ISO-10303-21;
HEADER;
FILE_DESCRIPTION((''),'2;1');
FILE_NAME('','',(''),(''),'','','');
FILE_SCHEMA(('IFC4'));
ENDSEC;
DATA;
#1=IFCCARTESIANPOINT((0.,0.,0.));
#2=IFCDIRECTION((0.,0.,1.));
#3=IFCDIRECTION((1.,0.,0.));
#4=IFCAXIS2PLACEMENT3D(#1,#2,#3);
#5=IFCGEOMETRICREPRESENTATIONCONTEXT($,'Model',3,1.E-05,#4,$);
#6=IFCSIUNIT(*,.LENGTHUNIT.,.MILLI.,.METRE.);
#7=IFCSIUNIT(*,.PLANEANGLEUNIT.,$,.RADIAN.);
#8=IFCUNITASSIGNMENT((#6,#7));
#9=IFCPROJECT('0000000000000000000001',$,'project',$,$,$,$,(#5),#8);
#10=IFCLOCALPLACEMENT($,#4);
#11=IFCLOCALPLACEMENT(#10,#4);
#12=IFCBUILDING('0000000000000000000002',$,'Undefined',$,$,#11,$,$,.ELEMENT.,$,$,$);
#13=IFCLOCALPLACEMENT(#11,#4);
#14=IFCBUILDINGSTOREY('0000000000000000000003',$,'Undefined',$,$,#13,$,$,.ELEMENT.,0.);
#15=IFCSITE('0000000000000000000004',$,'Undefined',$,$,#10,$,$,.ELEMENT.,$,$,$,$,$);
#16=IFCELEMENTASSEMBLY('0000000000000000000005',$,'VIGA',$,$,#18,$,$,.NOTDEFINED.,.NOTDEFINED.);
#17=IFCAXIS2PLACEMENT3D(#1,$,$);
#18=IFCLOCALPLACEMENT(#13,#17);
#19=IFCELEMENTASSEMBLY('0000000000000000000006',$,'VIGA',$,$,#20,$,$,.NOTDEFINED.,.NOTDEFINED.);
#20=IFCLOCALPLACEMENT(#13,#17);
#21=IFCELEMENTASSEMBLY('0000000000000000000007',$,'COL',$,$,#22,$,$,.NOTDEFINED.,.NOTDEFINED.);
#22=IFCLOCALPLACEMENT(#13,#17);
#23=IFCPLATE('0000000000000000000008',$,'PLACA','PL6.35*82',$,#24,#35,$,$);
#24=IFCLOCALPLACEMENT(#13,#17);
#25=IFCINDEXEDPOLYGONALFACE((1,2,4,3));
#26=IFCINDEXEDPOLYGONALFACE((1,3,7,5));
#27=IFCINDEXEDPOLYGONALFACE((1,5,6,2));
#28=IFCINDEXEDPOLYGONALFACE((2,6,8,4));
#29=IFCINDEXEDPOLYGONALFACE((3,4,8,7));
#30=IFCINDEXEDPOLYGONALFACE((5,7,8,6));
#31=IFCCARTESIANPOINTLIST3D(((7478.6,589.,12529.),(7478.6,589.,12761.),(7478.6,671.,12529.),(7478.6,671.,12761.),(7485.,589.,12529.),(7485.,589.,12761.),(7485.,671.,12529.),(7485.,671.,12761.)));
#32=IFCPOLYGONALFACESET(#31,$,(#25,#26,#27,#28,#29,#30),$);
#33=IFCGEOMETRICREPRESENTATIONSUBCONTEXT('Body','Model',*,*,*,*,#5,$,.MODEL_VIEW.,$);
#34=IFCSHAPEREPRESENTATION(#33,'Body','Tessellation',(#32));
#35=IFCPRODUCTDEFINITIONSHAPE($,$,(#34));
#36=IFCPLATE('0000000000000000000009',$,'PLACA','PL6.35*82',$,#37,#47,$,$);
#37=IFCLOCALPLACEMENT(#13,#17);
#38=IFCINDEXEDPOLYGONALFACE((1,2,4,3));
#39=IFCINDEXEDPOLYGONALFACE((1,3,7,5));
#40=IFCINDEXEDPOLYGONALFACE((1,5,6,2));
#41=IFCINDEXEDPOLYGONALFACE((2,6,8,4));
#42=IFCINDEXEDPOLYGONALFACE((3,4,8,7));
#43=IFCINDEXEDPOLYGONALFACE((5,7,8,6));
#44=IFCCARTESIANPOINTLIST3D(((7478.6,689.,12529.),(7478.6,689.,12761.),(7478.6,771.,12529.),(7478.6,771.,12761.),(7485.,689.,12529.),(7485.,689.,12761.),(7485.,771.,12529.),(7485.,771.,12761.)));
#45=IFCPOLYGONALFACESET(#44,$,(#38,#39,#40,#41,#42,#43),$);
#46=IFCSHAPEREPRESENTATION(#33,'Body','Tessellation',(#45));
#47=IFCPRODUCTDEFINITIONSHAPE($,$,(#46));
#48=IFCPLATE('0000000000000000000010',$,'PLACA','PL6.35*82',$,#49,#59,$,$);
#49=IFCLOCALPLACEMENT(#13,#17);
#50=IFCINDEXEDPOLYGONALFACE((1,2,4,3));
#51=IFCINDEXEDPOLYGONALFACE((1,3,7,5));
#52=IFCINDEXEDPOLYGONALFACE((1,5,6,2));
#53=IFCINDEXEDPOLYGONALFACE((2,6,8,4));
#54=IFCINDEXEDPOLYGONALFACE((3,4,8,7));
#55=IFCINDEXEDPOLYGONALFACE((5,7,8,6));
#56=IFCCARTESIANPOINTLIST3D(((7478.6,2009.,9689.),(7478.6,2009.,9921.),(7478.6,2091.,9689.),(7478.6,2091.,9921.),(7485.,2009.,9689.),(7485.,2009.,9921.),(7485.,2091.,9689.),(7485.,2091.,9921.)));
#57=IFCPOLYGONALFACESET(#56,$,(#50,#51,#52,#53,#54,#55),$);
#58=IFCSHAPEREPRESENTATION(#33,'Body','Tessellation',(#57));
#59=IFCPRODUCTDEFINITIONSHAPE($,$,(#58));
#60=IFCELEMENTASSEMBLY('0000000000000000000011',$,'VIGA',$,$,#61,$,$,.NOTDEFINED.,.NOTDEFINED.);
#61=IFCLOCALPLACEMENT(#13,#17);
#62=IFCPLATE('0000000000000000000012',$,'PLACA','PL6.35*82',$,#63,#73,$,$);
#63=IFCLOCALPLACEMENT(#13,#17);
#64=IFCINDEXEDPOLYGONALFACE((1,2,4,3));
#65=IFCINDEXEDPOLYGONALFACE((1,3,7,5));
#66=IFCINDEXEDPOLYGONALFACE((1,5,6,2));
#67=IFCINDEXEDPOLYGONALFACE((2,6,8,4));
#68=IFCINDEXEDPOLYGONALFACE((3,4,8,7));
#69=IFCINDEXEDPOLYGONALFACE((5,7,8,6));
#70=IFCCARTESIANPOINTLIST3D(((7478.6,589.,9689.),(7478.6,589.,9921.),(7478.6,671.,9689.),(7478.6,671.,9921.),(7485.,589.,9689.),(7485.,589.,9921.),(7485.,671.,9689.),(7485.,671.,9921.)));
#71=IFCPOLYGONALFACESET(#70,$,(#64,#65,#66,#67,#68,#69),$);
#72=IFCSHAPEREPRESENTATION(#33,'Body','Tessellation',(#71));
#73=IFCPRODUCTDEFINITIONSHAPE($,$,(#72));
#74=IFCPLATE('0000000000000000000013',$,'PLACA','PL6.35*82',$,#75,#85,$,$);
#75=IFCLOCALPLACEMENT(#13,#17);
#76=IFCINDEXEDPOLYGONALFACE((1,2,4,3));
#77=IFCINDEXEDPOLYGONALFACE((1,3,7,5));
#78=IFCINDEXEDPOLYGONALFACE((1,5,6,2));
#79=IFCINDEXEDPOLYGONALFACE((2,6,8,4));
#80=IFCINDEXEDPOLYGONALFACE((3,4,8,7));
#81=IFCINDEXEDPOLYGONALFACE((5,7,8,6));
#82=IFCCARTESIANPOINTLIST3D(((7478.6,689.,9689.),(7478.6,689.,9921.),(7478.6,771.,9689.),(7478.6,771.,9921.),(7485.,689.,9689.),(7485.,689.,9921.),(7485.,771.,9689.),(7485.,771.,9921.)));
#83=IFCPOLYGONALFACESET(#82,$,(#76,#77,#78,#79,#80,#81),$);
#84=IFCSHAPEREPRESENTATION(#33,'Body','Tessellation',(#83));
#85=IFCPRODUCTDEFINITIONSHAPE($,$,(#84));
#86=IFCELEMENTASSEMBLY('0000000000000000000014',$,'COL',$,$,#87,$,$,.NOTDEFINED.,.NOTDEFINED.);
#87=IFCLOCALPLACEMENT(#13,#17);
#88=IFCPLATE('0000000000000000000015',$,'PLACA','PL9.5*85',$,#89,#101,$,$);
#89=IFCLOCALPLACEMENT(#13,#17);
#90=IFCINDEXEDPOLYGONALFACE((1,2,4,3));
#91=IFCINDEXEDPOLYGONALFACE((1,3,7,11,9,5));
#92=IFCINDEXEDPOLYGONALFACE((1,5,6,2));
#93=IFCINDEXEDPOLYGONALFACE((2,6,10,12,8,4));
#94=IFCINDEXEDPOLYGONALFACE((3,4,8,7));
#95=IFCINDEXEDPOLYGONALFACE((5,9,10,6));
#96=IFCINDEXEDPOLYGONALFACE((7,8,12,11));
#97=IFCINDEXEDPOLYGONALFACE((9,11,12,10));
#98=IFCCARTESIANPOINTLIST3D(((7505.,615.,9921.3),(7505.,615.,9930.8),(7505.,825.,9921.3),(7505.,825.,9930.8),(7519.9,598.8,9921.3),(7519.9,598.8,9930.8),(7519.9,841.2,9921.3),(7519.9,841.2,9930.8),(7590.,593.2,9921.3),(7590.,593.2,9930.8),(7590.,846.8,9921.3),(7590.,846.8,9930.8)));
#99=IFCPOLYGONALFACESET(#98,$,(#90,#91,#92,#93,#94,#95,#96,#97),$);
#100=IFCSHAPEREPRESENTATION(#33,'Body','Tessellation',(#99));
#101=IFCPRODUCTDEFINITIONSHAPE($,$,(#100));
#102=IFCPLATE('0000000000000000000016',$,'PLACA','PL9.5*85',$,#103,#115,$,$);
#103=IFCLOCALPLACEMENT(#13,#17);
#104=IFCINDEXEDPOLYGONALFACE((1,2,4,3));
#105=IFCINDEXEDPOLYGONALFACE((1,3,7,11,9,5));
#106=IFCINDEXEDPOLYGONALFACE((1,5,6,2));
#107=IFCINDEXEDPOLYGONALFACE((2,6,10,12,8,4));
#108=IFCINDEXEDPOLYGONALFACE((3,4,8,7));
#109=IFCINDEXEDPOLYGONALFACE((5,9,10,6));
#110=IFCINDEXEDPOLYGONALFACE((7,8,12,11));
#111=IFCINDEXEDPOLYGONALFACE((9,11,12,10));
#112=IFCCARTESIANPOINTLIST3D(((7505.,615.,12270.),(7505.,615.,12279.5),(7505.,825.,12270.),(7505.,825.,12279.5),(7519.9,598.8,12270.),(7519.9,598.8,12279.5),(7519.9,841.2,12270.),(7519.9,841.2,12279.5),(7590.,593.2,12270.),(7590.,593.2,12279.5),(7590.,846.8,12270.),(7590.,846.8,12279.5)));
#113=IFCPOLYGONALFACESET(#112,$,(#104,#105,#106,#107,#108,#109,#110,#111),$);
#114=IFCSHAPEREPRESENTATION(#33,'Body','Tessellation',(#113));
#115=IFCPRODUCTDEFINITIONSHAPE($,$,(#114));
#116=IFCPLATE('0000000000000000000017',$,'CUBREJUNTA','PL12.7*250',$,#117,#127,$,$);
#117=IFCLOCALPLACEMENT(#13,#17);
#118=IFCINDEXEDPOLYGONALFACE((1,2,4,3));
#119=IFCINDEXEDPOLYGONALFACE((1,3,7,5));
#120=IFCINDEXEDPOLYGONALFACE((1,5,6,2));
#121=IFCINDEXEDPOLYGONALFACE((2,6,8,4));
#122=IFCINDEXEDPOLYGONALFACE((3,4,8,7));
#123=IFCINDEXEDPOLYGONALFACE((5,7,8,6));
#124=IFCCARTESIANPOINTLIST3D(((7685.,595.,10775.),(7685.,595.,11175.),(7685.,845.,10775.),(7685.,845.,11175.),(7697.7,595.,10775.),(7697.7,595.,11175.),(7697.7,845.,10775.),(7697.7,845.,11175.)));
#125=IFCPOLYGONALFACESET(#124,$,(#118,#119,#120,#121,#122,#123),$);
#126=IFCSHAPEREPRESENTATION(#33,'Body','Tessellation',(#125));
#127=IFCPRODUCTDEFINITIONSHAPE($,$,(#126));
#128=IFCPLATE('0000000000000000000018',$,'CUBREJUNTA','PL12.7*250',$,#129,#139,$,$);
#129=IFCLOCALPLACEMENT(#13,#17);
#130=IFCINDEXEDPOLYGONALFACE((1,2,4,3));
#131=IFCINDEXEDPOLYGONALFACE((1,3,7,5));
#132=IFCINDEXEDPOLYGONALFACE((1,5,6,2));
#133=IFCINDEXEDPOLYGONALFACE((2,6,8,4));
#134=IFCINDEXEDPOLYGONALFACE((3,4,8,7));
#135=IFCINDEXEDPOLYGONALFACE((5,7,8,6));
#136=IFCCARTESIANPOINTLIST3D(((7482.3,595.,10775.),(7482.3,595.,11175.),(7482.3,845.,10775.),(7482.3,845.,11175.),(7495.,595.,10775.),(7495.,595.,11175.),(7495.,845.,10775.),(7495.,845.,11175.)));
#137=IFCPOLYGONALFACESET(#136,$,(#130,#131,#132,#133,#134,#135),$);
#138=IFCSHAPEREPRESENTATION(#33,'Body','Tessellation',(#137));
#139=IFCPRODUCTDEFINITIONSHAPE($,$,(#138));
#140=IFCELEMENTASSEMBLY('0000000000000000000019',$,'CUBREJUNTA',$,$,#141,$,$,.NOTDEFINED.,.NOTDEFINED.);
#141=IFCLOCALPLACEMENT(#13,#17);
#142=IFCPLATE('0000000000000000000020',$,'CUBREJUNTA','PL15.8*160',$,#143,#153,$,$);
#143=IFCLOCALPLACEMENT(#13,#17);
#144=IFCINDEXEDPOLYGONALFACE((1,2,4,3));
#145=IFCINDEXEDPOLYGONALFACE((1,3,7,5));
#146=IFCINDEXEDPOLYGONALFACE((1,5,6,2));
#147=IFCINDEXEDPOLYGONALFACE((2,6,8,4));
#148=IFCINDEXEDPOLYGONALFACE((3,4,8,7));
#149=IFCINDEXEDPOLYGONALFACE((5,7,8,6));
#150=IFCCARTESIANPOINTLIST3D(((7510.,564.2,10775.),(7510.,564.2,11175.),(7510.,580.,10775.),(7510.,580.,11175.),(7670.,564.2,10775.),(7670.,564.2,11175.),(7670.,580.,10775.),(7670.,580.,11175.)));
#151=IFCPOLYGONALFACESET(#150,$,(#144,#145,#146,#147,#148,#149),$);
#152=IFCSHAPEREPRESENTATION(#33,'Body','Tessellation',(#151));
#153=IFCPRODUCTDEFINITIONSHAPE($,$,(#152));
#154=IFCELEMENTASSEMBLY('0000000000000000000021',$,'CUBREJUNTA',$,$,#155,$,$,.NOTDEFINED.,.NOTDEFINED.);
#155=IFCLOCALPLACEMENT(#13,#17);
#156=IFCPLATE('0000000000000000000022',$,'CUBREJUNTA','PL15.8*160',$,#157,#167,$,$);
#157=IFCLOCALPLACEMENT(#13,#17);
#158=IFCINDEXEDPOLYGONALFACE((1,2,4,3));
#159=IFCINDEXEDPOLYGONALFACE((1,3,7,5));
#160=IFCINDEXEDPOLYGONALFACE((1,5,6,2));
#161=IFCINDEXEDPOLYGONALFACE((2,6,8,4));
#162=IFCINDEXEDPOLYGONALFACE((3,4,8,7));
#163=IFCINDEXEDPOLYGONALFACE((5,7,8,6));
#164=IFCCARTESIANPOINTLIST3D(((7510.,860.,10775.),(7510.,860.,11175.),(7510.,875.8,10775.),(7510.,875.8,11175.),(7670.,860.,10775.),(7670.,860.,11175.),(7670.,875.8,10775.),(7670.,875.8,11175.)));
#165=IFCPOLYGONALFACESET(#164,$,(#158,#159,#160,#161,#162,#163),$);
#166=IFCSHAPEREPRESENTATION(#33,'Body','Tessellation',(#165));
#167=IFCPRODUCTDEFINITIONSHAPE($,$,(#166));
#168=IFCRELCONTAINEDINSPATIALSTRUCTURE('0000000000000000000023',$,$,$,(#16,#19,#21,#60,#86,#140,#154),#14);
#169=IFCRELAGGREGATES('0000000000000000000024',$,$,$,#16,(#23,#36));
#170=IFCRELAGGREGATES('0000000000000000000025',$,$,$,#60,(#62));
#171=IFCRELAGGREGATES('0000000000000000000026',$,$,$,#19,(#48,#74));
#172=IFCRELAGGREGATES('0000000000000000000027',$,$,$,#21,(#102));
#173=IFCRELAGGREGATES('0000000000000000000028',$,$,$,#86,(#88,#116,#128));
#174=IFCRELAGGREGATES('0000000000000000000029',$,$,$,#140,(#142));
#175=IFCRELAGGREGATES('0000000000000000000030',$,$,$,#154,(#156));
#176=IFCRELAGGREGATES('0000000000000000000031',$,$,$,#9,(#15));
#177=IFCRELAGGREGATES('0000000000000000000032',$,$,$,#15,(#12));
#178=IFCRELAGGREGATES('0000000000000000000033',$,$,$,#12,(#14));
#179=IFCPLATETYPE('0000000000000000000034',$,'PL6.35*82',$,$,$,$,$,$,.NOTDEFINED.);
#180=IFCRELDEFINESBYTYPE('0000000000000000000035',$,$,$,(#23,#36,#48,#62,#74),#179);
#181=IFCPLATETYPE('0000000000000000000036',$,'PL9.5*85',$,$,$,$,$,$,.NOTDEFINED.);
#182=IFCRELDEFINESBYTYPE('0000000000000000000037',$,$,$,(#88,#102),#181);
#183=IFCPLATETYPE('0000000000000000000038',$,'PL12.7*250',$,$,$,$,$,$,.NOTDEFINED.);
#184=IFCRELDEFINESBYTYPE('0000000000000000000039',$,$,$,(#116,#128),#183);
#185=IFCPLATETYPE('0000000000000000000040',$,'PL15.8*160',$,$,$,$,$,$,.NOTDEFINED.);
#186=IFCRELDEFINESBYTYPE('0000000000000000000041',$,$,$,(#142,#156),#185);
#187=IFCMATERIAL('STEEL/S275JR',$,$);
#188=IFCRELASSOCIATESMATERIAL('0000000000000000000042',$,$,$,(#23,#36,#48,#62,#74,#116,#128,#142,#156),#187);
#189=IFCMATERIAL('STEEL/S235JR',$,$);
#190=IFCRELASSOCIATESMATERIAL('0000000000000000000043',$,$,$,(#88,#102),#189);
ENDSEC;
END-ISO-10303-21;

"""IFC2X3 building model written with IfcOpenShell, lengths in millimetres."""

from ifc_helpers import new_model, si_unit, frame, origin_with_axes, place, context, subcontext, project, spatial, polyline, outline, extrude, material, type_object, element, aggregate, save


model = new_model("IFC2X3")

# Units and contexts
model_context = context("Model", 3, precision=1e-05, world=origin_with_axes())
body_context = subcontext(model_context, "Body", "Model", "MODEL_VIEW")
ifc_project = project(units=[si_unit("LENGTHUNIT", "METRE", prefix="MILLI"), si_unit("PLANEANGLEUNIT", "RADIAN")], contexts=[model_context])

# Site, building, storey
site_placement = place(None, origin_with_axes())
site = spatial("IfcSite", under=ifc_project, at=site_placement, Name="Undefined", CompositionType="ELEMENT")
building_placement = place(site_placement, origin_with_axes())
building = spatial("IfcBuilding", under=site, at=building_placement, Name="Undefined", CompositionType="ELEMENT")
storey_placement = place(building_placement, origin_with_axes())
storey = spatial("IfcBuildingStorey", under=building, at=storey_placement, Name="Undefined", CompositionType="ELEMENT", Elevation=0.0)

# Shared definitions
ifc_material_1 = material(Name="STEEL/S275JR")

# Element assemblies
assembly_1_placement = place(storey_placement, origin_with_axes())
assembly_1 = element("IfcElementAssembly", 1, at=assembly_1_placement, inside=storey, Name="VIGA", AssemblyPlace="NOTDEFINED", PredefinedType="NOTDEFINED")
ifc_material_2 = material(Name="STEEL/S235JR")
assembly_2_placement = place(storey_placement, origin_with_axes())
assembly_2 = element("IfcElementAssembly", 2, at=assembly_2_placement, inside=storey, Name="VIGA", AssemblyPlace="NOTDEFINED", PredefinedType="NOTDEFINED")

# Element assembly
assembly_3_placement = place(storey_placement, origin_with_axes())
assembly_3 = element("IfcElementAssembly", 3, at=assembly_3_placement, inside=storey, Name="COL", AssemblyPlace="NOTDEFINED", PredefinedType="NOTDEFINED")

# Plates
plate_type_1 = type_object("IfcPlateType", Name="PL6.35*82", PredefinedType="NOTDEFINED")
plate_1_placement = place(assembly_1_placement, frame((7481.8, 589.0, 12761.0), z_axis=(-1.0, 0.0, 0.0), x_axis=(0.0, 1.0, 0.0)))
plate_1 = element("IfcPlate", 4, at=plate_1_placement, type_object=plate_type_1, material=ifc_material_1, Name="PLACA", Description="PL6.35*82", context=body_context, shape_type="SweptSolid", body=[
    extrude(outline(polyline([(0.0, 0.0), (82.0, 0.0), (82.0, 232.0), (0.0, 232.0), (0.0, 0.0)])), frame((0.0, 0.0, -3.2), z_axis=(0.0, 0.0, 1.0), x_axis=(1.0, 0.0, 0.0)), (0.0, 0.0, 1.0), 6.4),
])
plate_2_placement = place(assembly_1_placement, frame((7481.8, 689.0, 12761.0), z_axis=(-1.0, 0.0, 0.0), x_axis=(0.0, 1.0, 0.0)))
plate_2 = element("IfcPlate", 5, at=plate_2_placement, type_object=plate_type_1, material=ifc_material_1, Name="PLACA", Description="PL6.35*82", context=body_context, shape_type="SweptSolid", body=[
    extrude(outline(polyline([(0.0, 0.0), (82.0, 0.0), (82.0, 232.0), (0.0, 232.0), (0.0, 0.0)])), frame((0.0, 0.0, -3.2), z_axis=(0.0, 0.0, 1.0), x_axis=(1.0, 0.0, 0.0)), (0.0, 0.0, 1.0), 6.4),
])
aggregate(assembly_1, [plate_1, plate_2])
plate_3_placement = place(assembly_2_placement, frame((7481.8, 2009.0, 9921.0), z_axis=(-1.0, 0.0, 0.0), x_axis=(0.0, 1.0, 0.0)))
plate_3 = element("IfcPlate", 6, at=plate_3_placement, type_object=plate_type_1, material=ifc_material_1, Name="PLACA", Description="PL6.35*82", context=body_context, shape_type="SweptSolid", body=[
    extrude(outline(polyline([(0.0, 0.0), (82.0, 0.0), (82.0, 232.0), (0.0, 232.0), (0.0, 0.0)])), frame((0.0, 0.0, -3.2), z_axis=(0.0, 0.0, 1.0), x_axis=(1.0, 0.0, 0.0)), (0.0, 0.0, 1.0), 6.4),
])

# Element assembly, plate
assembly_4_placement = place(storey_placement, origin_with_axes())
assembly_4 = element("IfcElementAssembly", 7, at=assembly_4_placement, inside=storey, Name="VIGA", AssemblyPlace="NOTDEFINED", PredefinedType="NOTDEFINED")
plate_4_placement = place(assembly_4_placement, frame((7481.8, 589.0, 9921.0), z_axis=(-1.0, 0.0, 0.0), x_axis=(0.0, 1.0, 0.0)))
plate_4 = element("IfcPlate", 8, at=plate_4_placement, type_object=plate_type_1, material=ifc_material_1, Name="PLACA", Description="PL6.35*82", context=body_context, shape_type="SweptSolid", body=[
    extrude(outline(polyline([(0.0, 0.0), (82.0, 0.0), (82.0, 232.0), (0.0, 232.0), (0.0, 0.0)])), frame((0.0, 0.0, -3.2), z_axis=(0.0, 0.0, 1.0), x_axis=(1.0, 0.0, 0.0)), (0.0, 0.0, 1.0), 6.4),
])
aggregate(assembly_4, [plate_4])

# Plate
plate_5_placement = place(assembly_2_placement, frame((7481.8, 689.0, 9921.0), z_axis=(-1.0, 0.0, 0.0), x_axis=(0.0, 1.0, 0.0)))
plate_5 = element("IfcPlate", 9, at=plate_5_placement, type_object=plate_type_1, material=ifc_material_1, Name="PLACA", Description="PL6.35*82", context=body_context, shape_type="SweptSolid", body=[
    extrude(outline(polyline([(0.0, 0.0), (82.0, 0.0), (82.0, 232.0), (0.0, 232.0), (0.0, 0.0)])), frame((0.0, 0.0, -3.2), z_axis=(0.0, 0.0, 1.0), x_axis=(1.0, 0.0, 0.0)), (0.0, 0.0, 1.0), 6.4),
])
aggregate(assembly_2, [plate_3, plate_5])

# Element assembly, plate
assembly_5_placement = place(storey_placement, origin_with_axes())
assembly_5 = element("IfcElementAssembly", 10, at=assembly_5_placement, inside=storey, Name="COL", AssemblyPlace="NOTDEFINED", PredefinedType="NOTDEFINED")
plate_type_2 = type_object("IfcPlateType", Name="PL9.5*85", PredefinedType="NOTDEFINED")
plate_6_placement = place(assembly_5_placement, frame((7590.0, 846.8, 9926.0), z_axis=(0.0, 0.0, 1.0), x_axis=(-0.996815, -0.079745, 0.0)))
plate_6 = element("IfcPlate", 11, at=plate_6_placement, type_object=plate_type_2, material=ifc_material_2, Name="PLACA", Description="PL9.5*85", context=body_context, shape_type="SweptSolid", body=[
    extrude(outline(polyline([(0.0, 0.0), (70.3, 0.0), (86.5, 15.0), (103.2, 224.3), (89.6, 241.6), (20.2, 252.8), (0.0, 0.0)])), frame((0.0, 0.0, -4.7), z_axis=(0.0, 0.0, 1.0), x_axis=(1.0, 0.0, 0.0)), (0.0, 0.0, 1.0), 9.5),
])

# Plates
plate_7_placement = place(assembly_3_placement, frame((7590.0, 846.8, 12274.8), z_axis=(0.0, 0.0, 1.0), x_axis=(-0.996815, -0.079745, 0.0)))
plate_7 = element("IfcPlate", 12, at=plate_7_placement, type_object=plate_type_2, material=ifc_material_2, Name="PLACA", Description="PL9.5*85", context=body_context, shape_type="SweptSolid", body=[
    extrude(outline(polyline([(0.0, 0.0), (70.3, 0.0), (86.5, 15.0), (103.2, 224.3), (89.6, 241.6), (20.2, 252.8), (0.0, 0.0)])), frame((0.0, 0.0, -4.7), z_axis=(0.0, 0.0, 1.0), x_axis=(1.0, 0.0, 0.0)), (0.0, 0.0, 1.0), 9.5),
])
aggregate(assembly_3, [plate_7])
plate_type_3 = type_object("IfcPlateType", Name="PL12.7*250", PredefinedType="NOTDEFINED")
plate_8_placement = place(assembly_5_placement, frame((7691.3, 845.0, 11175.0), z_axis=(-1.0, 0.0, 0.0), x_axis=(0.0, 0.0, -1.0)))
plate_8 = element("IfcPlate", 13, at=plate_8_placement, type_object=plate_type_3, material=ifc_material_1, Name="CUBREJUNTA", Description="PL12.7*250", context=body_context, shape_type="SweptSolid", body=[
    extrude(outline(polyline([(0.0, 0.0), (400.0, 0.0), (400.0, 250.0), (0.0, 250.0), (0.0, 0.0)])), frame((0.0, 0.0, -6.3), z_axis=(0.0, 0.0, 1.0), x_axis=(1.0, 0.0, 0.0)), (0.0, 0.0, 1.0), 12.7),
])
plate_9_placement = place(assembly_5_placement, frame((7488.7, 845.0, 11175.0), z_axis=(-1.0, 0.0, 0.0), x_axis=(0.0, 0.0, -1.0)))
plate_9 = element("IfcPlate", 14, at=plate_9_placement, type_object=plate_type_3, material=ifc_material_1, Name="CUBREJUNTA", Description="PL12.7*250", context=body_context, shape_type="SweptSolid", body=[
    extrude(outline(polyline([(0.0, 0.0), (400.0, 0.0), (400.0, 250.0), (0.0, 250.0), (0.0, 0.0)])), frame((0.0, 0.0, -6.3), z_axis=(0.0, 0.0, 1.0), x_axis=(1.0, 0.0, 0.0)), (0.0, 0.0, 1.0), 12.7),
])
aggregate(assembly_5, [plate_6, plate_8, plate_9])

# Element assemblies, plates
assembly_6_placement = place(storey_placement, origin_with_axes())
assembly_6 = element("IfcElementAssembly", 15, at=assembly_6_placement, inside=storey, Name="CUBREJUNTA", AssemblyPlace="NOTDEFINED", PredefinedType="NOTDEFINED")
plate_type_4 = type_object("IfcPlateType", Name="PL15.8*160", PredefinedType="NOTDEFINED")
plate_10_placement = place(assembly_6_placement, frame((7670.0, 572.1, 10775.0), z_axis=(0.0, 1.0, 0.0), x_axis=(-1.0, 0.0, 0.0)))
plate_10 = element("IfcPlate", 16, at=plate_10_placement, type_object=plate_type_4, material=ifc_material_1, Name="CUBREJUNTA", Description="PL15.8*160", context=body_context, shape_type="SweptSolid", body=[
    extrude(outline(polyline([(0.0, 0.0), (160.0, 0.0), (160.0, 400.0), (0.0, 400.0), (0.0, 0.0)])), frame((0.0, 0.0, -7.9), z_axis=(0.0, 0.0, 1.0), x_axis=(1.0, 0.0, 0.0)), (0.0, 0.0, 1.0), 15.8),
])
aggregate(assembly_6, [plate_10])
assembly_7_placement = place(storey_placement, origin_with_axes())
assembly_7 = element("IfcElementAssembly", 17, at=assembly_7_placement, inside=storey, Name="CUBREJUNTA", AssemblyPlace="NOTDEFINED", PredefinedType="NOTDEFINED")
plate_11_placement = place(assembly_7_placement, frame((7670.0, 867.9, 10775.0), z_axis=(0.0, 1.0, 0.0), x_axis=(-1.0, 0.0, 0.0)))
plate_11 = element("IfcPlate", 18, at=plate_11_placement, type_object=plate_type_4, material=ifc_material_1, Name="CUBREJUNTA", Description="PL15.8*160", context=body_context, shape_type="SweptSolid", body=[
    extrude(outline(polyline([(0.0, 0.0), (160.0, 0.0), (160.0, 400.0), (0.0, 400.0), (0.0, 0.0)])), frame((0.0, 0.0, -7.9), z_axis=(0.0, 0.0, 1.0), x_axis=(1.0, 0.0, 0.0)), (0.0, 0.0, 1.0), 15.8),
])
aggregate(assembly_7, [plate_11])

save(model, "model.ifc")
